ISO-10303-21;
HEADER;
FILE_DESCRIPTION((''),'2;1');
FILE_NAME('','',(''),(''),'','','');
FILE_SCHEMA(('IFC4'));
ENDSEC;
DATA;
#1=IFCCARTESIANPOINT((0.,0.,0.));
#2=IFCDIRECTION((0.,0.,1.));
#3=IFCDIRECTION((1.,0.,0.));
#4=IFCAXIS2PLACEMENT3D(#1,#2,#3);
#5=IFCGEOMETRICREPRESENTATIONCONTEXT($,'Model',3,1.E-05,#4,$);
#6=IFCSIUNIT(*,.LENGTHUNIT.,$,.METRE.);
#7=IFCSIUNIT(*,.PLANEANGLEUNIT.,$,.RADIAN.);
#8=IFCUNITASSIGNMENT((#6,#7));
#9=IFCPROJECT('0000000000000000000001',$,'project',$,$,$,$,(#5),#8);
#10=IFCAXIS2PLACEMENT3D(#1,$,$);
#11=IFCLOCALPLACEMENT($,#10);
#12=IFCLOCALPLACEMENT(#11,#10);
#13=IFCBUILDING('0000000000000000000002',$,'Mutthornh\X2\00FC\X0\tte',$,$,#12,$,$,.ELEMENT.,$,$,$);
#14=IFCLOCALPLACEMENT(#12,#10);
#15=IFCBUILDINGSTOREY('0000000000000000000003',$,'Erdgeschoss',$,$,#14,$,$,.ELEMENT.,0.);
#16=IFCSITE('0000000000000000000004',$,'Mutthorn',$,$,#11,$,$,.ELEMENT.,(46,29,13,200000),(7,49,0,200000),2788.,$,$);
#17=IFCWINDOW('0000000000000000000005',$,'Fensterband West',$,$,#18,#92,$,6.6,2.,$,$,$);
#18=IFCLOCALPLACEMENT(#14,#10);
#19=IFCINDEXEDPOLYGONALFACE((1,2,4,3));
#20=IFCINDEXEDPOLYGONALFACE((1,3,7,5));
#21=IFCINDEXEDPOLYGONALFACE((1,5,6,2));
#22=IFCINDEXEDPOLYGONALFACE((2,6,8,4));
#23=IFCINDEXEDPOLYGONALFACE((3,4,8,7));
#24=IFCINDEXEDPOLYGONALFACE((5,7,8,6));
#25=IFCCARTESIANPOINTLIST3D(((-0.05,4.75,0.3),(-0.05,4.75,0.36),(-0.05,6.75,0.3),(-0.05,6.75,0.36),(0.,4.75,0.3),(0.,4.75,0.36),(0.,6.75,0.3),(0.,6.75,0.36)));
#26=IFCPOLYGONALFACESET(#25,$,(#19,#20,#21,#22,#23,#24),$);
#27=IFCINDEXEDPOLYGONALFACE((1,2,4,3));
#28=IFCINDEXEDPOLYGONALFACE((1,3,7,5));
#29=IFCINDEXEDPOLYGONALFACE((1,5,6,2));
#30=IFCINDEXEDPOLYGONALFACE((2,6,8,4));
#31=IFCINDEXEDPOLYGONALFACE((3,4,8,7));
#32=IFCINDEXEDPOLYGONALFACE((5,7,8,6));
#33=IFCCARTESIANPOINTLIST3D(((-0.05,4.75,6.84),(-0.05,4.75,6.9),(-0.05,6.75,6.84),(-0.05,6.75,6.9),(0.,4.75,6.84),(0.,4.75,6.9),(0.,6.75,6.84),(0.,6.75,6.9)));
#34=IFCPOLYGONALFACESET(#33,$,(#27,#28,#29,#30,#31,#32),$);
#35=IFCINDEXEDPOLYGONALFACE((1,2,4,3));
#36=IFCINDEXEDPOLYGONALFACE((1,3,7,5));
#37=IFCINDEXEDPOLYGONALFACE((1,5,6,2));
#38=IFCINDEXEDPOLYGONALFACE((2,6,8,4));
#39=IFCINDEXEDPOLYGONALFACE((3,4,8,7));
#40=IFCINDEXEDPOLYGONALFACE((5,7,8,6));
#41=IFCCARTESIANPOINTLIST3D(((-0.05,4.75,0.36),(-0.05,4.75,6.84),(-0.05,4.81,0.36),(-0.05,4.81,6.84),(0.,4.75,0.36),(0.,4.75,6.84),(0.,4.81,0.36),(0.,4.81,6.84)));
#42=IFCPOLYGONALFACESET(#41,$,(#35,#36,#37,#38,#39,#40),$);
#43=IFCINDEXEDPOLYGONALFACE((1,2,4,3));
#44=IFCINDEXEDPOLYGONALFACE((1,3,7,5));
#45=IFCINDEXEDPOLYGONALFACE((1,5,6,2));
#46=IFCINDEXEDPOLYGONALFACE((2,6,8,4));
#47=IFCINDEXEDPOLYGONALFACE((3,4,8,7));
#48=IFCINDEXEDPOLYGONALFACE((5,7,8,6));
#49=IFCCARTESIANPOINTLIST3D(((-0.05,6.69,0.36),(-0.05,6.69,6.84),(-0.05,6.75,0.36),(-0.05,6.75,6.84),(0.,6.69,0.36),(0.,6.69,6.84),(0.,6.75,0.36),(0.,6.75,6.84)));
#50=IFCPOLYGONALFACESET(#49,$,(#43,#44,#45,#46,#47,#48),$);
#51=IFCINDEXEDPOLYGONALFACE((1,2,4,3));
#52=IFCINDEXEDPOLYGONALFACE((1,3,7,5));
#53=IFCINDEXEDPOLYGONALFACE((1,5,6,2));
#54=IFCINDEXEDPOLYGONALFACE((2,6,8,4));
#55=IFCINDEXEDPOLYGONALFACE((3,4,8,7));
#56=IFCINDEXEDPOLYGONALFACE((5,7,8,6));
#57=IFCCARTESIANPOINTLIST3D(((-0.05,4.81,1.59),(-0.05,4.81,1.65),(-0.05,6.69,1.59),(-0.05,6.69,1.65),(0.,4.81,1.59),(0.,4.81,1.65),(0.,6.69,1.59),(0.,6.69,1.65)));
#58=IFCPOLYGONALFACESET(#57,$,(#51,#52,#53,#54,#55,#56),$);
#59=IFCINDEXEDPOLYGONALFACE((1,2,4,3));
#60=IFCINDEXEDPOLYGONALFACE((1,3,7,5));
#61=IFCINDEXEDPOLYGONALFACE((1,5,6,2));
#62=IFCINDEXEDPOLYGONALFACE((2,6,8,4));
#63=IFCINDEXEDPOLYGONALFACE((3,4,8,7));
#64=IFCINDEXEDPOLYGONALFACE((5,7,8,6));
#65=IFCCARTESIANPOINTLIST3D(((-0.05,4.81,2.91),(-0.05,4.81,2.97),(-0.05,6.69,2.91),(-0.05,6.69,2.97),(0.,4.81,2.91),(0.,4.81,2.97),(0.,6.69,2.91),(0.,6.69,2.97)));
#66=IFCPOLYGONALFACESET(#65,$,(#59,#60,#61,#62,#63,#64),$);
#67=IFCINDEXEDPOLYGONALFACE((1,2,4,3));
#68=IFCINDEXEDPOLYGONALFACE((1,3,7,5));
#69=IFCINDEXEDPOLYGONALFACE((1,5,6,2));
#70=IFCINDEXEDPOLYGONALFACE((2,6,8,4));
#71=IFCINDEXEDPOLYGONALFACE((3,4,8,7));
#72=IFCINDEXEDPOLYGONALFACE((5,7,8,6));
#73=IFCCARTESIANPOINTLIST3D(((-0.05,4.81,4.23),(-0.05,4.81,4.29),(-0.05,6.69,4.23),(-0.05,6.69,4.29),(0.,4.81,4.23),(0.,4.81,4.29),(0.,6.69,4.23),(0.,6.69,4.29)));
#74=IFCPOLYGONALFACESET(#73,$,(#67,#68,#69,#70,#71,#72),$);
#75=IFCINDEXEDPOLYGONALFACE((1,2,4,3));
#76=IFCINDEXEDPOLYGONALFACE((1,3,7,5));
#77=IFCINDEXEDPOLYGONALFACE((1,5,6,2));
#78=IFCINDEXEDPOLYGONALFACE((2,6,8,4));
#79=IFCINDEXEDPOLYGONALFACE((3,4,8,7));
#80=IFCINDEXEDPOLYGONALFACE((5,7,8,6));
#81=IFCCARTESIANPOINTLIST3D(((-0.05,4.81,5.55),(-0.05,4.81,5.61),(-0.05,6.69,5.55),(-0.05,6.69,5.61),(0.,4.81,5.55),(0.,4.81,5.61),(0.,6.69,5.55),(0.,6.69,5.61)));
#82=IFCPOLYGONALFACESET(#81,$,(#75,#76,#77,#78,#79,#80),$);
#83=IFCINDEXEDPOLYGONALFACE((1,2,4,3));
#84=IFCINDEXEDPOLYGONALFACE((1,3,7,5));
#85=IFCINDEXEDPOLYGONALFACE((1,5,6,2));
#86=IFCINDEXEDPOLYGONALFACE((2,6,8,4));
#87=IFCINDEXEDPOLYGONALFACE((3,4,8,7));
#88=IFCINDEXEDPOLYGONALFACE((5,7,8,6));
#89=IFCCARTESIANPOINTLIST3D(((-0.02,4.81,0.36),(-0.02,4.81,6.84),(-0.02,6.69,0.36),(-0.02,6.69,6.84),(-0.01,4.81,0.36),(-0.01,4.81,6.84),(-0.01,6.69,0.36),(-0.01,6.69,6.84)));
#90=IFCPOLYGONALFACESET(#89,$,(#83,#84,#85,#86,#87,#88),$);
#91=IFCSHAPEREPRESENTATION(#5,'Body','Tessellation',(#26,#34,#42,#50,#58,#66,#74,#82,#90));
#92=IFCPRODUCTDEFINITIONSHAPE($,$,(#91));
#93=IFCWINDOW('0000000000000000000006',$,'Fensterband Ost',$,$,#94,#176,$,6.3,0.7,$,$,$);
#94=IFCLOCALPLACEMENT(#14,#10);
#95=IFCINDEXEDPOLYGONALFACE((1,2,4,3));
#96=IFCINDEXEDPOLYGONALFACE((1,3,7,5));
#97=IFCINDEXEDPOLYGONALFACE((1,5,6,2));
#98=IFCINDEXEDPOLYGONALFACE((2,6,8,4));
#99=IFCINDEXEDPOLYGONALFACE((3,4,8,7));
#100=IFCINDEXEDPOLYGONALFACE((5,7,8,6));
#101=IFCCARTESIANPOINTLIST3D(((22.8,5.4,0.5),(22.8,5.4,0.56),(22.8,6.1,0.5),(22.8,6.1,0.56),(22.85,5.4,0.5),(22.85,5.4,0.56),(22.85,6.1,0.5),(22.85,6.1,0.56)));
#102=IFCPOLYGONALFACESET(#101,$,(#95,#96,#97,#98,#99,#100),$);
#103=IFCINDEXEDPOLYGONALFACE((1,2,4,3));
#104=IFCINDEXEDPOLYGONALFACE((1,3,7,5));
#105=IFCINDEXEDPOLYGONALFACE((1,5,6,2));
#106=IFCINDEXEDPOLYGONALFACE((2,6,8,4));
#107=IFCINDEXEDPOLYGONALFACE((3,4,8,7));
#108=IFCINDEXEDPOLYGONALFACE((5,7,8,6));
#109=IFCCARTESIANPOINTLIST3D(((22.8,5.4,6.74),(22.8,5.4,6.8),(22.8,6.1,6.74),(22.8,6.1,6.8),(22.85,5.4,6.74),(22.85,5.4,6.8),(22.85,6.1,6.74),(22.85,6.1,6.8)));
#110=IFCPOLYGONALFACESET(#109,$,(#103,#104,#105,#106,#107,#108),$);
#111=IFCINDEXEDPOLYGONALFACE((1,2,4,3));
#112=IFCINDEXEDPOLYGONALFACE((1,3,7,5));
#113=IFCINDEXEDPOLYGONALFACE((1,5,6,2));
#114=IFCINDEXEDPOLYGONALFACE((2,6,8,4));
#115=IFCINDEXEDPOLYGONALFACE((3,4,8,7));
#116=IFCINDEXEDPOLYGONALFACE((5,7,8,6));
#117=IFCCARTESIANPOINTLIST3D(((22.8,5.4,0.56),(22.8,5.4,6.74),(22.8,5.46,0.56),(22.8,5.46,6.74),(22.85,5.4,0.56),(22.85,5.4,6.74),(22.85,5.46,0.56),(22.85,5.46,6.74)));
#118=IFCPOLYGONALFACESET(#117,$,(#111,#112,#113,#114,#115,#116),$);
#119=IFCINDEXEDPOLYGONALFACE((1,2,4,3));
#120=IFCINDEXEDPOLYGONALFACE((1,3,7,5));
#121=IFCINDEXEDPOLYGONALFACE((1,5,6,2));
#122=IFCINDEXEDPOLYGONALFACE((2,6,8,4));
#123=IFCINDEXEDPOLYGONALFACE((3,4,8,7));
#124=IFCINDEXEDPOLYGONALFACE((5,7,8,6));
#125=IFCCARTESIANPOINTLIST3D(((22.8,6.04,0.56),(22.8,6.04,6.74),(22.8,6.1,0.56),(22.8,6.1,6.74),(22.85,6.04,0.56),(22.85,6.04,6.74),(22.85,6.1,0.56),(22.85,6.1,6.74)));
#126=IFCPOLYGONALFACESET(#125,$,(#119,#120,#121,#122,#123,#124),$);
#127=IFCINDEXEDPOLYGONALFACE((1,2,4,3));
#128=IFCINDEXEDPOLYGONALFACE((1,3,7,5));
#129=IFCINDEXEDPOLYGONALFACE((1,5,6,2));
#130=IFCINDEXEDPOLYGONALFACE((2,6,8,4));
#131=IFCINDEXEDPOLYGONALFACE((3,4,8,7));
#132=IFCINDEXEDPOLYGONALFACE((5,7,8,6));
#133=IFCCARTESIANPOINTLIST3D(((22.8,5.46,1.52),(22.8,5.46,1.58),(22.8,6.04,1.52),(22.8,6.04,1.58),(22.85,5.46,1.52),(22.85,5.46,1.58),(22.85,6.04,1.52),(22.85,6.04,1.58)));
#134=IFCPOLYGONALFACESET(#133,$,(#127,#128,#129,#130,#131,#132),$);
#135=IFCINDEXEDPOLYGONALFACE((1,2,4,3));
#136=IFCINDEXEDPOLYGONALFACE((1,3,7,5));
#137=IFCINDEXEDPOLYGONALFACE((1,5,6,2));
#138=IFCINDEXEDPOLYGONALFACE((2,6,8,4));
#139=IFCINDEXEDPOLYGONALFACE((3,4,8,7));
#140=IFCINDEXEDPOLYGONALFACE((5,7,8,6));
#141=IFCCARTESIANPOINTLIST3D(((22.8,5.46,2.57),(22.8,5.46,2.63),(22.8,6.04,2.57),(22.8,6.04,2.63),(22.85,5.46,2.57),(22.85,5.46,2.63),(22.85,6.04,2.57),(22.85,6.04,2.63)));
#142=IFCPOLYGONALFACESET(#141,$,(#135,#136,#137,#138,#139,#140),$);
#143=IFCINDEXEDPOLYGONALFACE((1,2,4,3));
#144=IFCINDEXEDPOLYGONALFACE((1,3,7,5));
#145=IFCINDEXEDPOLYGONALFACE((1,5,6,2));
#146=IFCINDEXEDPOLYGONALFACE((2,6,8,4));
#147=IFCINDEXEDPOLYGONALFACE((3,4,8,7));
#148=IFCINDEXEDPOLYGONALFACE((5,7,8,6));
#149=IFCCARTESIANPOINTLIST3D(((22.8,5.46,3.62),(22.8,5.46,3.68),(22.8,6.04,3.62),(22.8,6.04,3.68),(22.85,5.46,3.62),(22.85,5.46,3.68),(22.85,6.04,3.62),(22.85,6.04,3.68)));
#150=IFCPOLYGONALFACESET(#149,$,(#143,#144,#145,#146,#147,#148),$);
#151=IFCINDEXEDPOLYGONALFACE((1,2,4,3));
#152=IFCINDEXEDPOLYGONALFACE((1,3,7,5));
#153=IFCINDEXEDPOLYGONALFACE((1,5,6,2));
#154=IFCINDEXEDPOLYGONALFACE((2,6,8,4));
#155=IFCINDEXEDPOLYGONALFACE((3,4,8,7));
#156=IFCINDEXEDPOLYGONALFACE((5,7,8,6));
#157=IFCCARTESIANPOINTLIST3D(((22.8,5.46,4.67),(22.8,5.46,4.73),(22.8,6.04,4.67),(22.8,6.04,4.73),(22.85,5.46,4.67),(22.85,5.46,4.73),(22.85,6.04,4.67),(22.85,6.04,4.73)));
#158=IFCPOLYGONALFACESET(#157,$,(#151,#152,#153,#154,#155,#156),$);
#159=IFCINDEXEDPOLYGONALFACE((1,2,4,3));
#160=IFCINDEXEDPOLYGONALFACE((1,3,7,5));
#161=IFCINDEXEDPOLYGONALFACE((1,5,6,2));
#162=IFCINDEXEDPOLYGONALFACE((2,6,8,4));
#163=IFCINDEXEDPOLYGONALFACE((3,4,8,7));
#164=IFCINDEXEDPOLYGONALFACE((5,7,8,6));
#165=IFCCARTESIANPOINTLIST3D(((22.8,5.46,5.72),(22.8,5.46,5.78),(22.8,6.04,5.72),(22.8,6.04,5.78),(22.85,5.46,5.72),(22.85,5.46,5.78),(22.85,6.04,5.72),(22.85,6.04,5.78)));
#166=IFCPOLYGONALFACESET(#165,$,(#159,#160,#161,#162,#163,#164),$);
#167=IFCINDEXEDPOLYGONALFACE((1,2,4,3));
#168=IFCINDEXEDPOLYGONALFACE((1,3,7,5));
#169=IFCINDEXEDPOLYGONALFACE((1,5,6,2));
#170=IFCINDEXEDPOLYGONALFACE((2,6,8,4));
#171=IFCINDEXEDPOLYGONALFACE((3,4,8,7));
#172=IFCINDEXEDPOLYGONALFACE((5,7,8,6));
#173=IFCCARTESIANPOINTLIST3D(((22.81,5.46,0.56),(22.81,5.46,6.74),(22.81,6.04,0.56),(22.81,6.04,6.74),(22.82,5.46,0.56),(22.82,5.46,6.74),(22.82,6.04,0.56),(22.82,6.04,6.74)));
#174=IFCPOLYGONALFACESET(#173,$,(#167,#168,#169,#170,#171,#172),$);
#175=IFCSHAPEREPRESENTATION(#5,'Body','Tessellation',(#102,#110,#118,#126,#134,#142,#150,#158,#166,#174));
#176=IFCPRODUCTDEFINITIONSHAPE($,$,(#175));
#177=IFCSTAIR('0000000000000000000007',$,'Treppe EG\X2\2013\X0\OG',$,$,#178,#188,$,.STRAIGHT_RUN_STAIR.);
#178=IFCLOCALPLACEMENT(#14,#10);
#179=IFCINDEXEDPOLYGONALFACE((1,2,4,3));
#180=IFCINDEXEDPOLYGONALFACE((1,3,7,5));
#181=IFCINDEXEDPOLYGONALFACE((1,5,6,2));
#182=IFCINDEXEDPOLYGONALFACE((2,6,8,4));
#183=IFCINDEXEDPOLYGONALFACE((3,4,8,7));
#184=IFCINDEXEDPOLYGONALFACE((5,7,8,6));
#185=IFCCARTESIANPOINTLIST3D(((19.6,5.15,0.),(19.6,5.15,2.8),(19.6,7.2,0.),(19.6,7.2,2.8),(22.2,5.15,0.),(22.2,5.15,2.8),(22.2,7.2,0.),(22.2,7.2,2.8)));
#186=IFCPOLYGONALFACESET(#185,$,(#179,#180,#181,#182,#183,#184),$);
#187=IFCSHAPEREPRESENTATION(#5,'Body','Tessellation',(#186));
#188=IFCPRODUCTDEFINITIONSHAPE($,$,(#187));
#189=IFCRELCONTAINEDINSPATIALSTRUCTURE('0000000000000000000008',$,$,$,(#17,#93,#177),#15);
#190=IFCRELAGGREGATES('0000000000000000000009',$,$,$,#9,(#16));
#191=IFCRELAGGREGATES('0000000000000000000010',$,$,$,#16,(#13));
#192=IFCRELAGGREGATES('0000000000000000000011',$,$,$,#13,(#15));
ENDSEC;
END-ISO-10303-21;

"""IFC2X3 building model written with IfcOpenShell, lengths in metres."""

from ifc_helpers import new_model, si_unit, frame, frame_2d, origin, origin_with_axes, place, context, project, spatial, rectangle, extrude, element, save


model = new_model("IFC2X3")

# Units and contexts
model_context = context("Model", 3, precision=1e-05, world=origin_with_axes())
ifc_project = project(units=[si_unit("LENGTHUNIT", "METRE"), si_unit("PLANEANGLEUNIT", "RADIAN")], contexts=[model_context])

# Site, building, storey
site_placement = place(None, origin())
site = spatial("IfcSite", under=ifc_project, at=site_placement, Name="Mutthorn", CompositionType="ELEMENT", RefLatitude=(46, 29, 13, 200000), RefLongitude=(7, 49, 0, 200000), RefElevation=2788.0)
building_placement = place(site_placement, origin())
building = spatial("IfcBuilding", under=site, at=building_placement, Name="Mutthornhütte", CompositionType="ELEMENT")
storey_placement = place(building_placement, origin())
storey = spatial("IfcBuildingStorey", under=building, at=storey_placement, Name="Erdgeschoss", CompositionType="ELEMENT", Elevation=0.0)

# Windows
window_1_placement = place(storey_placement, origin())
element("IfcWindow", 1, at=window_1_placement, inside=storey, Name="Fensterband West", OverallHeight=6.6, OverallWidth=2.0, context=model_context, shape_type="SweptSolid", body=[
    extrude(rectangle(XDim=0.05, YDim=2.0, at=frame_2d((0.025, 1.0))), frame((-0.05, 4.75, 0.3)), (0.0, 0.0, 1.0), 0.06),
    extrude(rectangle(XDim=0.05, YDim=2.0, at=frame_2d((0.025, 1.0))), frame((-0.05, 4.75, 6.84)), (0.0, 0.0, 1.0), 0.06),
    extrude(rectangle(XDim=0.05, YDim=0.06, at=frame_2d((0.025, 0.03))), frame((-0.05, 4.75, 0.36)), (0.0, 0.0, 1.0), 6.48),
    extrude(rectangle(XDim=0.05, YDim=0.06, at=frame_2d((0.025, 0.03))), frame((-0.05, 6.69, 0.36)), (0.0, 0.0, 1.0), 6.48),
    extrude(rectangle(XDim=0.05, YDim=1.88, at=frame_2d((0.025, 0.94))), frame((-0.05, 4.81, 1.59)), (0.0, 0.0, 1.0), 0.06),
    extrude(rectangle(XDim=0.05, YDim=1.88, at=frame_2d((0.025, 0.94))), frame((-0.05, 4.81, 2.91)), (0.0, 0.0, 1.0), 0.06),
    extrude(rectangle(XDim=0.05, YDim=1.88, at=frame_2d((0.025, 0.94))), frame((-0.05, 4.81, 4.23)), (0.0, 0.0, 1.0), 0.06),
    extrude(rectangle(XDim=0.05, YDim=1.88, at=frame_2d((0.025, 0.94))), frame((-0.05, 4.81, 5.55)), (0.0, 0.0, 1.0), 0.06),
    extrude(rectangle(XDim=0.01, YDim=1.88, at=frame_2d((0.005, 0.94))), frame((-0.02, 4.81, 0.36)), (0.0, 0.0, 1.0), 6.48),
])
window_2_placement = place(storey_placement, origin())
element("IfcWindow", 2, at=window_2_placement, inside=storey, Name="Fensterband Ost", OverallHeight=6.3, OverallWidth=0.7, context=model_context, shape_type="SweptSolid", body=[
    extrude(rectangle(XDim=0.05, YDim=0.7, at=frame_2d((0.025, 0.35))), frame((22.8, 5.4, 0.5)), (0.0, 0.0, 1.0), 0.06),
    extrude(rectangle(XDim=0.05, YDim=0.7, at=frame_2d((0.025, 0.35))), frame((22.8, 5.4, 6.74)), (0.0, 0.0, 1.0), 0.06),
    extrude(rectangle(XDim=0.05, YDim=0.06, at=frame_2d((0.025, 0.03))), frame((22.8, 5.4, 0.56)), (0.0, 0.0, 1.0), 6.18),
    extrude(rectangle(XDim=0.05, YDim=0.06, at=frame_2d((0.025, 0.03))), frame((22.8, 6.04, 0.56)), (0.0, 0.0, 1.0), 6.18),
    extrude(rectangle(XDim=0.05, YDim=0.58, at=frame_2d((0.025, 0.29))), frame((22.8, 5.46, 1.52)), (0.0, 0.0, 1.0), 0.06),
    extrude(rectangle(XDim=0.05, YDim=0.58, at=frame_2d((0.025, 0.29))), frame((22.8, 5.46, 2.57)), (0.0, 0.0, 1.0), 0.06),
    extrude(rectangle(XDim=0.05, YDim=0.58, at=frame_2d((0.025, 0.29))), frame((22.8, 5.46, 3.62)), (0.0, 0.0, 1.0), 0.06),
    extrude(rectangle(XDim=0.05, YDim=0.58, at=frame_2d((0.025, 0.29))), frame((22.8, 5.46, 4.67)), (0.0, 0.0, 1.0), 0.06),
    extrude(rectangle(XDim=0.05, YDim=0.58, at=frame_2d((0.025, 0.29))), frame((22.8, 5.46, 5.72)), (0.0, 0.0, 1.0), 0.06),
    extrude(rectangle(XDim=0.01, YDim=0.58, at=frame_2d((0.005, 0.29))), frame((22.81, 5.46, 0.56)), (0.0, 0.0, 1.0), 6.18),
])

# Stair
stair_placement = place(storey_placement, origin())
element("IfcStair", 3, at=stair_placement, inside=storey, Name="Treppe EG–OG", ShapeType="STRAIGHT_RUN_STAIR", context=model_context, shape_type="SweptSolid", body=[
    extrude(rectangle(XDim=2.6, YDim=2.05, at=frame_2d((1.3, 1.025))), frame((19.6, 5.15, 0.0)), (0.0, 0.0, 1.0), 2.8),
])

save(model, "model.ifc")
